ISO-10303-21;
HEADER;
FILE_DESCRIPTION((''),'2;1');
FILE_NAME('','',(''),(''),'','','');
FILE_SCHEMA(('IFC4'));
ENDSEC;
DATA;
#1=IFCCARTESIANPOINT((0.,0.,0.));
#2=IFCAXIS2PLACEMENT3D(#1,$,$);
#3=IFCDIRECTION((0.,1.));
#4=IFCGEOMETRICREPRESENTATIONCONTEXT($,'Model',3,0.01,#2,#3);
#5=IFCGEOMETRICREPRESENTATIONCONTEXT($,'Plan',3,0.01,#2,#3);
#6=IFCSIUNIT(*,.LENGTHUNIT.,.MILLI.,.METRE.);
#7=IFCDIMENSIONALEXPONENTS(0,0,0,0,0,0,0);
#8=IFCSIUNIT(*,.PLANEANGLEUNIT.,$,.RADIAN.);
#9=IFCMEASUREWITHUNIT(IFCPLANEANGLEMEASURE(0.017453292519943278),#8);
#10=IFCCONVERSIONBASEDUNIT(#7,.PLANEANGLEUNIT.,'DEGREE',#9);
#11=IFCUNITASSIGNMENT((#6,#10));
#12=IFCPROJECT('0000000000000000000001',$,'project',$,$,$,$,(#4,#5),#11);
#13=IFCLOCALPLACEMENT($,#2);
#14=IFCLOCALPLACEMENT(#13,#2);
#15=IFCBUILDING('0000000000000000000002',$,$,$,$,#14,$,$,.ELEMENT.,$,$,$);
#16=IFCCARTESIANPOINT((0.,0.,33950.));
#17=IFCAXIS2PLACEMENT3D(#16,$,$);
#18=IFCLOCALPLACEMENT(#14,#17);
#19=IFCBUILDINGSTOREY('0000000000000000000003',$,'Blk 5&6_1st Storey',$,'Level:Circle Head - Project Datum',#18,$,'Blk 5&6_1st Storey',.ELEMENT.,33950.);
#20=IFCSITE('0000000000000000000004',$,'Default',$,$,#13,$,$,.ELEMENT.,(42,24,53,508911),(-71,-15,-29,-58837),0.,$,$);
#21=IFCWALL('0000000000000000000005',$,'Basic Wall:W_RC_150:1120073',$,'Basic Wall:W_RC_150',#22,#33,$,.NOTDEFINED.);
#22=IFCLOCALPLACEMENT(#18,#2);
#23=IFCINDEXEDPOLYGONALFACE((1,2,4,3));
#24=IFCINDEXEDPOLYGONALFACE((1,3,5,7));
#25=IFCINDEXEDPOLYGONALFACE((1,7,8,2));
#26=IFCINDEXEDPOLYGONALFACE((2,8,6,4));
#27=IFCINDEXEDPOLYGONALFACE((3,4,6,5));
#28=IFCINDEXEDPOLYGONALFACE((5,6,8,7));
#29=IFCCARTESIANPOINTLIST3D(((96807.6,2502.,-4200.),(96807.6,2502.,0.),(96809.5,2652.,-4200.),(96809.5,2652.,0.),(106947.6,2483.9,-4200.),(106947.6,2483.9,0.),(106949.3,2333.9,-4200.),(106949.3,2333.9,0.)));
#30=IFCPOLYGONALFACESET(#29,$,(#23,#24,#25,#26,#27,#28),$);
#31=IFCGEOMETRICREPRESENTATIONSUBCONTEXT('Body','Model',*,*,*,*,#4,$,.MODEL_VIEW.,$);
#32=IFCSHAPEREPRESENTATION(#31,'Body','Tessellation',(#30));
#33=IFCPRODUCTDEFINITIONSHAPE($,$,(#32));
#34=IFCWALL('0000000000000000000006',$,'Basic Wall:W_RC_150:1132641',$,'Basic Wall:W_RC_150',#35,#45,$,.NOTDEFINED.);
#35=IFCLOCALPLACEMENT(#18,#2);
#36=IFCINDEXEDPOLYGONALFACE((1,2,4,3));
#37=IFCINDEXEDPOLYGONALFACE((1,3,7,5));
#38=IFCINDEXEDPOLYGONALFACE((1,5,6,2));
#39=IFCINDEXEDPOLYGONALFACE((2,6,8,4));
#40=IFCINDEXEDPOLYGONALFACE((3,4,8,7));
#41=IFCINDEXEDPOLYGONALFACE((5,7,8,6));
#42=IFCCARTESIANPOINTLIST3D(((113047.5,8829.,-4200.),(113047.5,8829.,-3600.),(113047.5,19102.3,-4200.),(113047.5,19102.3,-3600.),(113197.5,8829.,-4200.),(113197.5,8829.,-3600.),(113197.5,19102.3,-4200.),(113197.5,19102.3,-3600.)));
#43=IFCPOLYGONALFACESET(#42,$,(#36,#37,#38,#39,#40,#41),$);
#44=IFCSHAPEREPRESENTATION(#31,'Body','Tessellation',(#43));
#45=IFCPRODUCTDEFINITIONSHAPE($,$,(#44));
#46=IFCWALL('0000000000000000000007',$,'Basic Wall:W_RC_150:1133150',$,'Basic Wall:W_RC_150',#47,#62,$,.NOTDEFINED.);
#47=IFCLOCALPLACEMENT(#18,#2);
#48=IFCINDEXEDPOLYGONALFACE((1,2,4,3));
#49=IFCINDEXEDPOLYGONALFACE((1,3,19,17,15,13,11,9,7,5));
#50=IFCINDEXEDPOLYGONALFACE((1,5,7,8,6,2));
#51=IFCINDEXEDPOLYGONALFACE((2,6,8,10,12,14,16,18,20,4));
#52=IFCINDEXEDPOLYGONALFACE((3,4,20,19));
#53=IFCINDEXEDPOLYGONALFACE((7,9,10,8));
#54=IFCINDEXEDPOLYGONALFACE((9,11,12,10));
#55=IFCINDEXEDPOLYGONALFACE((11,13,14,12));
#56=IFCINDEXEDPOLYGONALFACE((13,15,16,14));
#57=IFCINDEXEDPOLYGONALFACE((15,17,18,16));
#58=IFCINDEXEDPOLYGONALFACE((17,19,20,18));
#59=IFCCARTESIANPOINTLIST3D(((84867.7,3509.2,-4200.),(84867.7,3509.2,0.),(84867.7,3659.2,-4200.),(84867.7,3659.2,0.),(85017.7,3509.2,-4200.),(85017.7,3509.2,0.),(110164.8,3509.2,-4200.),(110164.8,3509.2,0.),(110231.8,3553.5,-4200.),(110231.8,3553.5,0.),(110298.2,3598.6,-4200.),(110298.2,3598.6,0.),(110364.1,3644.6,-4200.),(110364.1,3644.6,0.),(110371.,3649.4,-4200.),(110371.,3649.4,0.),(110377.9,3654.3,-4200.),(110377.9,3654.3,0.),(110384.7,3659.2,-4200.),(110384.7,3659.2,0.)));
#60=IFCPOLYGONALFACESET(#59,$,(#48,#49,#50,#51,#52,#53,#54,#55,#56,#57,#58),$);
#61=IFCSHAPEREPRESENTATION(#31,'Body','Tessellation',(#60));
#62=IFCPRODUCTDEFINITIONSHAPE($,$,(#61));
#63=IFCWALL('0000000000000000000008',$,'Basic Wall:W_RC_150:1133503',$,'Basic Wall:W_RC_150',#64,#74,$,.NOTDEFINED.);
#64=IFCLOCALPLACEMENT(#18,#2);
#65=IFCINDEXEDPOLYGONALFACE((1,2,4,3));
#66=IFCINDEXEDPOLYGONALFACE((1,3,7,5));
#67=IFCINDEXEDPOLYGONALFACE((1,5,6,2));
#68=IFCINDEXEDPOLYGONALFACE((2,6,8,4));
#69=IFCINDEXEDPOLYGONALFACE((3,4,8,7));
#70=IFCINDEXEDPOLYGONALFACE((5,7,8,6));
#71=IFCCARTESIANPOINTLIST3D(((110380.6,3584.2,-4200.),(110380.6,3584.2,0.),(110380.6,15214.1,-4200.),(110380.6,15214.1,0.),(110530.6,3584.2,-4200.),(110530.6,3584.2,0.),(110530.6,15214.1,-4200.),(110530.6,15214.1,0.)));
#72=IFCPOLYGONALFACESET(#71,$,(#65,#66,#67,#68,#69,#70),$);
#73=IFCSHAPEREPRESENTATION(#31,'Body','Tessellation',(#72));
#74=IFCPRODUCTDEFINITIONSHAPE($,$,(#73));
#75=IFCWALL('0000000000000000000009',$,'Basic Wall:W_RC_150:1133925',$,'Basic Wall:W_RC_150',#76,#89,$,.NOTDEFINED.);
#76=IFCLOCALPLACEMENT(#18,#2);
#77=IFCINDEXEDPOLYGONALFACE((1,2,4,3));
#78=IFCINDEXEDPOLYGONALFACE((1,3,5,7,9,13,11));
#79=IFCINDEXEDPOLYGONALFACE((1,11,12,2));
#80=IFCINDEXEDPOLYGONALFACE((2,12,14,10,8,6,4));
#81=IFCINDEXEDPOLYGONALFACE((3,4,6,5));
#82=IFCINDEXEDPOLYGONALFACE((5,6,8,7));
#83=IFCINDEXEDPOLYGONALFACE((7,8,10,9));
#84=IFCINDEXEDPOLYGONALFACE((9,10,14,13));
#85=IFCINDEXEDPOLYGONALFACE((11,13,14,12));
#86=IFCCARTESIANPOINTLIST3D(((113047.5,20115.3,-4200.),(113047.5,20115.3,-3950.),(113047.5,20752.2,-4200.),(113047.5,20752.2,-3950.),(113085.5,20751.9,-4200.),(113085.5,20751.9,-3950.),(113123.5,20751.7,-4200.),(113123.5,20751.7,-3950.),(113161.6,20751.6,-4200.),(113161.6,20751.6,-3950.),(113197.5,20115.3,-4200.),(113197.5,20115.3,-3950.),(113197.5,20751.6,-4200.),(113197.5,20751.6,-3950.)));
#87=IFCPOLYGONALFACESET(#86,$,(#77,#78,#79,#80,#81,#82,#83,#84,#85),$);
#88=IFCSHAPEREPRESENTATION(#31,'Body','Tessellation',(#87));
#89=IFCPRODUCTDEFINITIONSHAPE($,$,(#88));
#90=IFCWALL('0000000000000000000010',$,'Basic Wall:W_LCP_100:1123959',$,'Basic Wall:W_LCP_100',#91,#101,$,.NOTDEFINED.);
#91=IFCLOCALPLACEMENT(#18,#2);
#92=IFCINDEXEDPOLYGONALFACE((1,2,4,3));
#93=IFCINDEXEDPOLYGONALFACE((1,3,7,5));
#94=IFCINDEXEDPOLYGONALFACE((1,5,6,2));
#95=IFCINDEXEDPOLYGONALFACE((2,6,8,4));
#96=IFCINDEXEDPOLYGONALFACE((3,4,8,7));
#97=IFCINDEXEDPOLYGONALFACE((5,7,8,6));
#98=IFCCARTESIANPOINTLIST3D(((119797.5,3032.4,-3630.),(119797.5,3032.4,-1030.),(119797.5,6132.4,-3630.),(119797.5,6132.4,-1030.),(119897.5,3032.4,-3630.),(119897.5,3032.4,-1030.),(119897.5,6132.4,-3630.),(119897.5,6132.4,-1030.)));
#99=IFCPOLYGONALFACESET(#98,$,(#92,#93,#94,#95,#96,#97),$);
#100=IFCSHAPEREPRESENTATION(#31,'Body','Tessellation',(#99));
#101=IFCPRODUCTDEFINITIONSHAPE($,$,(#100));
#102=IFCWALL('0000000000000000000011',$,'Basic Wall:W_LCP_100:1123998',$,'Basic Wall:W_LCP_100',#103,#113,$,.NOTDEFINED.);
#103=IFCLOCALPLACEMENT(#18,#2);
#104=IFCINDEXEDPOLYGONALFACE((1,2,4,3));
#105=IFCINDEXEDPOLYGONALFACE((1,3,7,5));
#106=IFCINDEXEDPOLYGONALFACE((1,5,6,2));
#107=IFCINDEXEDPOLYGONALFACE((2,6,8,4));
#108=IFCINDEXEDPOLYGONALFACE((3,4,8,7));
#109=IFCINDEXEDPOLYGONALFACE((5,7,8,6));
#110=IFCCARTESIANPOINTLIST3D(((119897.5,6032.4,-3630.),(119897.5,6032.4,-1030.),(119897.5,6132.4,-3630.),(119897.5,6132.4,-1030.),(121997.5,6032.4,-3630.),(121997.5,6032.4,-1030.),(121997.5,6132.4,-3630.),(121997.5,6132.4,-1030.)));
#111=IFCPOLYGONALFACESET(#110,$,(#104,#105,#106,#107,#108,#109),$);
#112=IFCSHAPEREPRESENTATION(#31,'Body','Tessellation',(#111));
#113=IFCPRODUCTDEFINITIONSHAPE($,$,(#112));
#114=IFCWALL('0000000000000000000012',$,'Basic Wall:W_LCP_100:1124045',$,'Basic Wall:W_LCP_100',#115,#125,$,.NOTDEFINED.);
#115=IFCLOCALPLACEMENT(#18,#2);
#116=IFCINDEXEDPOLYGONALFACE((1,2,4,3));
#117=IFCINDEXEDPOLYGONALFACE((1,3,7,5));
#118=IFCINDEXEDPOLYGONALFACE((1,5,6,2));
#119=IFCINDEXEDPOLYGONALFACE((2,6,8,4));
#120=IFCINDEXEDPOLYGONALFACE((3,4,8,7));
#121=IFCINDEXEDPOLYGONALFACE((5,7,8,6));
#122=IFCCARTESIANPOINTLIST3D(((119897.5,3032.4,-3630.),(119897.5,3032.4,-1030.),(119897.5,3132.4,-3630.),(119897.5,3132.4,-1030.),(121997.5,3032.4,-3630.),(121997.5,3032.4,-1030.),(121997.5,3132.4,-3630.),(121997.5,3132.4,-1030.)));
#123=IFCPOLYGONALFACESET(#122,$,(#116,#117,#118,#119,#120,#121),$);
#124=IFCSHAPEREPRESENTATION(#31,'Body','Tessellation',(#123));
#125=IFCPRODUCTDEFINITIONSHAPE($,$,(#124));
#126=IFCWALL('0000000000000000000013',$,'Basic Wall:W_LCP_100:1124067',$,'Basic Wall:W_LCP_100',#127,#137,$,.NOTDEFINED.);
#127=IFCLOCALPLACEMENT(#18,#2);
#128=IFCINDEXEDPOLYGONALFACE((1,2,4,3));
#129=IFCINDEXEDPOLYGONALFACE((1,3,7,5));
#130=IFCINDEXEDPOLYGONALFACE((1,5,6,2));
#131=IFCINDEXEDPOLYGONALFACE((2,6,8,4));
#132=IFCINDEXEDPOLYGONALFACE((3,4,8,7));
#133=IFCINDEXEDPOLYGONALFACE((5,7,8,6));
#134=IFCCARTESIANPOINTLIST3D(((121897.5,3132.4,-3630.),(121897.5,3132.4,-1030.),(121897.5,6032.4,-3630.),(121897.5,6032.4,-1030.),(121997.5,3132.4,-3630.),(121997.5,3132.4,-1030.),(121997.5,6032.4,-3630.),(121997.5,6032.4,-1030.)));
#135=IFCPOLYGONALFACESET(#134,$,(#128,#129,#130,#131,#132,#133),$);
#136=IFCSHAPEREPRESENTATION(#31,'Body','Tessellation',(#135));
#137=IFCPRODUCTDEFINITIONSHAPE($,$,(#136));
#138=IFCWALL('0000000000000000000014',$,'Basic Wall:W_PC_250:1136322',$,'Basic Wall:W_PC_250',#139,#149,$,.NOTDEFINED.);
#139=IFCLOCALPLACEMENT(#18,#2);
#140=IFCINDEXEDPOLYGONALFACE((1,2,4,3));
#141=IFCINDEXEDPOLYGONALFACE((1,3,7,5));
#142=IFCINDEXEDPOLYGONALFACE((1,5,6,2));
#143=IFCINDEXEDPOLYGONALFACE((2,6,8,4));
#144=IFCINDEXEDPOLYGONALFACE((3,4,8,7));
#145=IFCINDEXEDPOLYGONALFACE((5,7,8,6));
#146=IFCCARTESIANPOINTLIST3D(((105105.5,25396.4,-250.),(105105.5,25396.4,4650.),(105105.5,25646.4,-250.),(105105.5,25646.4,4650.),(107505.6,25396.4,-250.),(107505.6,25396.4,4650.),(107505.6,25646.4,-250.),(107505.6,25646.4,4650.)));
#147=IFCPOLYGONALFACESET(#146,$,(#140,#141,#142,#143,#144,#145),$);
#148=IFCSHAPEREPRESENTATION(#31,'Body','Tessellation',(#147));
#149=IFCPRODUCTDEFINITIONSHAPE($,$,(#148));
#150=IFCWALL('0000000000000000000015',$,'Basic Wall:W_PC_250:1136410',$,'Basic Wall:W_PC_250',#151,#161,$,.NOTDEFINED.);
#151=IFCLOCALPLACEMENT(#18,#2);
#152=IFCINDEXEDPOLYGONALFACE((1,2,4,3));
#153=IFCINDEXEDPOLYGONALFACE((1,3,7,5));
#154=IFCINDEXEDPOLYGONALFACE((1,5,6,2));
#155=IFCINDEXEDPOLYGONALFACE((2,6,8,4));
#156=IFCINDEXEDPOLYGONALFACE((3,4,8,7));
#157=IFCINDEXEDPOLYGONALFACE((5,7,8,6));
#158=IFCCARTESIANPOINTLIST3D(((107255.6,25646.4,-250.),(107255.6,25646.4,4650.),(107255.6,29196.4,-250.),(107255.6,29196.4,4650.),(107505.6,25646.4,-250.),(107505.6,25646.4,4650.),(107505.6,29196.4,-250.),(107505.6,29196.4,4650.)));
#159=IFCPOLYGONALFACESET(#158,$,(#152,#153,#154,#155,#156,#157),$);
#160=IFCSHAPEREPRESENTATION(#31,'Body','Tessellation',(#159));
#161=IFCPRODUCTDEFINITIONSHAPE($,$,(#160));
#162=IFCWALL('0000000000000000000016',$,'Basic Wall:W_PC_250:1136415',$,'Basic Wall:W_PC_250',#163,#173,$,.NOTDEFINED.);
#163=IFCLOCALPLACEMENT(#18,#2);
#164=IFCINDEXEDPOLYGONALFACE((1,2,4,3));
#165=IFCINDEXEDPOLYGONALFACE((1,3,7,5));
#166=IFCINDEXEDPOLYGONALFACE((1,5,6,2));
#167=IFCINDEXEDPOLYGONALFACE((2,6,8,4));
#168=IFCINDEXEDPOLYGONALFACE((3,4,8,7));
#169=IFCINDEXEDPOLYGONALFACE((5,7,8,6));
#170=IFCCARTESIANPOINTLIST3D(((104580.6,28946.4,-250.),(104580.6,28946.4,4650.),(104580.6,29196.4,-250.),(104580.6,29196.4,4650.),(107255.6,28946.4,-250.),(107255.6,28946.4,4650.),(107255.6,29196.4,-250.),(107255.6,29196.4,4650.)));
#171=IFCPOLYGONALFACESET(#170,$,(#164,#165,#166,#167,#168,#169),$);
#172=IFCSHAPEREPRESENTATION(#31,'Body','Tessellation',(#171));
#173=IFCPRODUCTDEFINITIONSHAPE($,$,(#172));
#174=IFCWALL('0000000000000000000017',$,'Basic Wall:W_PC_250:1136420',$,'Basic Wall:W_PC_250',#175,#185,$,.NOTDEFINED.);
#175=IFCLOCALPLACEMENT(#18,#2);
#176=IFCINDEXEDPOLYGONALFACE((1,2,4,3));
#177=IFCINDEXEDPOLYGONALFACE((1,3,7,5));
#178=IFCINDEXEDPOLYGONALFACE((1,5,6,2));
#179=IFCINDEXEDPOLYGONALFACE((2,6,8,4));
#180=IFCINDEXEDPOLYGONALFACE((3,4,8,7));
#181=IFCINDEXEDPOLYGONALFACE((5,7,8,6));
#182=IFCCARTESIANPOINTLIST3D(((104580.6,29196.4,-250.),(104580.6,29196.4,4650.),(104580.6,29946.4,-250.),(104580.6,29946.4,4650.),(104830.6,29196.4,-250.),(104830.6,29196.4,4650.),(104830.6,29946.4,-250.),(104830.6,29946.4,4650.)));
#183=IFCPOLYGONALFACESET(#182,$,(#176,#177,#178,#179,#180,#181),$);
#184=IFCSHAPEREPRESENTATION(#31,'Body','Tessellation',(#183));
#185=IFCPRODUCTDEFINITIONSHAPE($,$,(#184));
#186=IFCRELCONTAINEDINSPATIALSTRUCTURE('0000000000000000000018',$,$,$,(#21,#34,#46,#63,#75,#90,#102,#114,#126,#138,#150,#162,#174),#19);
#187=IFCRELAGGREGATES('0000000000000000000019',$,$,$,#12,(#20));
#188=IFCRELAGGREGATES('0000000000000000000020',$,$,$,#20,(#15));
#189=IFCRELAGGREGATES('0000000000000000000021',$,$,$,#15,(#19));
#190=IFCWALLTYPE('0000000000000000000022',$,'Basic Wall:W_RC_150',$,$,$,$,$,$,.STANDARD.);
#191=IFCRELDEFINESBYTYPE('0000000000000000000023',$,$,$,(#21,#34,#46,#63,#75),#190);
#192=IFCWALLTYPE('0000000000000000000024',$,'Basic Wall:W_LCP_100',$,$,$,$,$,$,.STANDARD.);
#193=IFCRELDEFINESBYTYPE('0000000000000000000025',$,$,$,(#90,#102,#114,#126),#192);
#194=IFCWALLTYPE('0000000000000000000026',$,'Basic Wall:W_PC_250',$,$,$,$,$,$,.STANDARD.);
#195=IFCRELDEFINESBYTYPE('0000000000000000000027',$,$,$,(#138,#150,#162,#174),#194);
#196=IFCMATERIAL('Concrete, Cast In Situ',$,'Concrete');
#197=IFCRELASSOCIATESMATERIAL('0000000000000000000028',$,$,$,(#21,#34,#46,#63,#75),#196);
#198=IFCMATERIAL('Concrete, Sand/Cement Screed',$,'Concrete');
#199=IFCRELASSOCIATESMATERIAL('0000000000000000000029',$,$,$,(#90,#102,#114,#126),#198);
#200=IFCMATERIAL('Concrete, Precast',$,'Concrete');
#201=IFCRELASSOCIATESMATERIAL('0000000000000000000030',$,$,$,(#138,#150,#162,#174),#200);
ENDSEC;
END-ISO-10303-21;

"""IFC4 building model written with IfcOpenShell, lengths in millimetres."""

from ifc_helpers import new_model, entity, si_unit, converted_unit, direction, frame, origin, place, context, subcontext, project, spatial, line, arc, indexed_curve, outline, extrude, material, type_object, element, save


model = new_model("IFC4")

# Units and contexts
model_context = context("Model", 3, precision=0.01, world=origin(), true_north=direction((0.0, 1.0)))
plan_context = context("Plan", 3, precision=0.01, world=origin(), true_north=direction((0.0, 1.0)))
body_context = subcontext(model_context, "Body", "Model", "MODEL_VIEW")
ifc_project = project(units=[si_unit("LENGTHUNIT", "METRE", prefix="MILLI"), converted_unit("PLANEANGLEUNIT", "DEGREE", entity("IfcPlaneAngleMeasure", 0.017453292519943278), si_unit("PLANEANGLEUNIT", "RADIAN"), dimensions=[0, 0, 0, 0, 0, 0, 0])], contexts=[model_context, plan_context])

# Site, building, storey
site_placement = place(None, origin())
site = spatial("IfcSite", under=ifc_project, at=site_placement, Name="Default", CompositionType="ELEMENT", RefLatitude=(42, 24, 53, 508911), RefLongitude=(-71, -15, -29, -58837), RefElevation=0.0)
building_placement = place(site_placement, origin())
building = spatial("IfcBuilding", under=site, at=building_placement, CompositionType="ELEMENT")
storey_placement = place(building_placement, frame((0.0, 0.0, 33950.0)))
storey = spatial("IfcBuildingStorey", under=building, at=storey_placement, Name="Blk 5&6_1st Storey", ObjectType="Level:Circle Head - Project Datum", LongName="Blk 5&6_1st Storey", CompositionType="ELEMENT", Elevation=33950.0)

# Walls
ifc_material_1 = material(Name="Concrete, Cast In Situ", Category="Concrete")
wall_type_1 = type_object("IfcWallType", Name="Basic Wall:W_RC_150", PredefinedType="STANDARD")
wall_1_placement = place(storey_placement, frame((106950.5, 2408.9, -4200.0), z_axis=(0.0, 0.0, 1.0), x_axis=(-0.999863, 0.016573, 0.0)))
element("IfcWall", 1, at=wall_1_placement, inside=storey, type_object=wall_type_1, material=ifc_material_1, Name="Basic Wall:W_RC_150:1120073", ObjectType="Basic Wall:W_RC_150", PredefinedType="NOTDEFINED", context=body_context, shape_type="SweptSolid", body=[
    extrude(outline(indexed_curve([(10143.7, -75.0), (10143.1, 75.0), (0.0, 75.0), (4.2, -75.0), (10143.7, -75.0)], self_intersect=False)), origin(), (0.0, 0.0, 1.0), 4200.0),
])
wall_2_placement = place(storey_placement, frame((113122.5, 8829.0, -4200.0), z_axis=(0.0, 0.0, 1.0), x_axis=(0.0, 1.0, 0.0)))
element("IfcWall", 2, at=wall_2_placement, inside=storey, type_object=wall_type_1, material=ifc_material_1, Name="Basic Wall:W_RC_150:1132641", ObjectType="Basic Wall:W_RC_150", PredefinedType="NOTDEFINED", context=body_context, shape_type="SweptSolid", body=[
    extrude(outline(indexed_curve([(10273.3, 75.0), (0.0, 75.0), (0.0, -75.0), (10273.3, -75.0), (10273.3, 75.0)], self_intersect=False)), origin(), (0.0, 0.0, 1.0), 600.0),
])
wall_3_placement = place(storey_placement, frame((110384.7, 3584.2, -4200.0), z_axis=(0.0, 0.0, 1.0), x_axis=(-1.0, 0.0, 0.0)))
element("IfcWall", 3, at=wall_3_placement, inside=storey, type_object=wall_type_1, material=ifc_material_1, Name="Basic Wall:W_RC_150:1133150", ObjectType="Basic Wall:W_RC_150", PredefinedType="NOTDEFINED", context=body_context, shape_type="SweptSolid", body=[
    extrude(outline(indexed_curve([(25517.0, -75.0), (25517.0, 75.0), (25367.0, 75.0), (219.9, 75.0), (119.6, 8.3), (20.6, -60.3), (10.3, -67.7), (0.0, -75.0)], segments=[line(1, 2, 3, 4), arc(4, 5, 6), arc(6, 7, 8), line(8, 1)], self_intersect=False)), origin(), (0.0, 0.0, 1.0), 4200.0),
])
wall_4_placement = place(storey_placement, frame((110455.6, 15214.1, -4200.0), z_axis=(0.0, 0.0, 1.0), x_axis=(0.0, -1.0, 0.0)))
element("IfcWall", 4, at=wall_4_placement, inside=storey, type_object=wall_type_1, material=ifc_material_1, Name="Basic Wall:W_RC_150:1133503", ObjectType="Basic Wall:W_RC_150", PredefinedType="NOTDEFINED", context=body_context, shape_type="SweptSolid", body=[
    extrude(outline(indexed_curve([(11629.9, 75.0), (0.0, 75.0), (0.0, -75.0), (11629.9, -75.0), (11629.9, 75.0)], self_intersect=False)), origin(), (0.0, 0.0, 1.0), 4200.0),
])
wall_5_placement = place(storey_placement, frame((113122.5, 20115.3, -4200.0), z_axis=(0.0, 0.0, 1.0), x_axis=(0.0, 1.0, 0.0)))
element("IfcWall", 5, at=wall_5_placement, inside=storey, type_object=wall_type_1, material=ifc_material_1, Name="Basic Wall:W_RC_150:1133925", ObjectType="Basic Wall:W_RC_150", PredefinedType="NOTDEFINED", context=body_context, shape_type="SweptSolid", body=[
    extrude(outline(indexed_curve([(636.3, -75.0), (636.3, -39.1), (636.5, 18.0), (636.9, 75.0), (0.0, 75.0), (0.0, -75.0)], segments=[line(1, 2), arc(2, 3, 4), line(4, 5, 6, 1)], self_intersect=False)), origin(), (0.0, 0.0, 1.0), 250.0),
])
ifc_material_2 = material(Name="Concrete, Sand/Cement Screed", Category="Concrete")
wall_type_2 = type_object("IfcWallType", Name="Basic Wall:W_LCP_100", PredefinedType="STANDARD")
wall_6_placement = place(storey_placement, frame((119847.5, 6132.4, -3630.0), z_axis=(0.0, 0.0, 1.0), x_axis=(0.0, -1.0, 0.0)))
element("IfcWall", 6, at=wall_6_placement, inside=storey, type_object=wall_type_2, material=ifc_material_2, Name="Basic Wall:W_LCP_100:1123959", ObjectType="Basic Wall:W_LCP_100", PredefinedType="NOTDEFINED", context=body_context, shape_type="SweptSolid", body=[
    extrude(outline(indexed_curve([(3100.0, 50.0), (0.0, 50.0), (0.0, -50.0), (3100.0, -50.0), (3100.0, 50.0)], self_intersect=False)), origin(), (0.0, 0.0, 1.0), 2600.0),
])
wall_7_placement = place(storey_placement, frame((119897.5, 6082.4, -3630.0)))
element("IfcWall", 7, at=wall_7_placement, inside=storey, type_object=wall_type_2, material=ifc_material_2, Name="Basic Wall:W_LCP_100:1123998", ObjectType="Basic Wall:W_LCP_100", PredefinedType="NOTDEFINED", context=body_context, shape_type="SweptSolid", body=[
    extrude(outline(indexed_curve([(2100.0, 50.0), (0.0, 50.0), (0.0, -50.0), (2100.0, -50.0), (2100.0, 50.0)], self_intersect=False)), origin(), (0.0, 0.0, 1.0), 2600.0),
])
wall_8_placement = place(storey_placement, frame((119897.5, 3082.4, -3630.0)))
element("IfcWall", 8, at=wall_8_placement, inside=storey, type_object=wall_type_2, material=ifc_material_2, Name="Basic Wall:W_LCP_100:1124045", ObjectType="Basic Wall:W_LCP_100", PredefinedType="NOTDEFINED", context=body_context, shape_type="SweptSolid", body=[
    extrude(outline(indexed_curve([(2100.0, 50.0), (0.0, 50.0), (0.0, -50.0), (2100.0, -50.0), (2100.0, 50.0)], self_intersect=False)), origin(), (0.0, 0.0, 1.0), 2600.0),
])
wall_9_placement = place(storey_placement, frame((121947.5, 6032.4, -3630.0), z_axis=(0.0, 0.0, 1.0), x_axis=(0.0, -1.0, 0.0)))
element("IfcWall", 9, at=wall_9_placement, inside=storey, type_object=wall_type_2, material=ifc_material_2, Name="Basic Wall:W_LCP_100:1124067", ObjectType="Basic Wall:W_LCP_100", PredefinedType="NOTDEFINED", context=body_context, shape_type="SweptSolid", body=[
    extrude(outline(indexed_curve([(2900.0, 50.0), (0.0, 50.0), (0.0, -50.0), (2900.0, -50.0), (2900.0, 50.0)], self_intersect=False)), origin(), (0.0, 0.0, 1.0), 2600.0),
])
ifc_material_3 = material(Name="Concrete, Precast", Category="Concrete")
wall_type_3 = type_object("IfcWallType", Name="Basic Wall:W_PC_250", PredefinedType="STANDARD")
wall_10_placement = place(storey_placement, frame((105105.5, 25521.4, -250.0)))
element("IfcWall", 10, at=wall_10_placement, inside=storey, type_object=wall_type_3, material=ifc_material_3, Name="Basic Wall:W_PC_250:1136322", ObjectType="Basic Wall:W_PC_250", PredefinedType="NOTDEFINED", context=body_context, shape_type="SweptSolid", body=[
    extrude(outline(indexed_curve([(2400.2, 125.0), (0.0, 125.0), (0.0, -125.0), (2400.2, -125.0), (2400.2, 125.0)], self_intersect=False)), origin(), (0.0, 0.0, 1.0), 4900.0),
])
wall_11_placement = place(storey_placement, frame((107380.6, 25646.4, -250.0), z_axis=(0.0, 0.0, 1.0), x_axis=(0.0, 1.0, 0.0)))
element("IfcWall", 11, at=wall_11_placement, inside=storey, type_object=wall_type_3, material=ifc_material_3, Name="Basic Wall:W_PC_250:1136410", ObjectType="Basic Wall:W_PC_250", PredefinedType="NOTDEFINED", context=body_context, shape_type="SweptSolid", body=[
    extrude(outline(indexed_curve([(3550.0, 125.0), (0.0, 125.0), (0.0, -125.0), (3550.0, -125.0), (3550.0, 125.0)], self_intersect=False)), origin(), (0.0, 0.0, 1.0), 4900.0),
])
wall_12_placement = place(storey_placement, frame((107255.6, 29071.4, -250.0), z_axis=(0.0, 0.0, 1.0), x_axis=(-1.0, 0.0, 0.0)))
element("IfcWall", 12, at=wall_12_placement, inside=storey, type_object=wall_type_3, material=ifc_material_3, Name="Basic Wall:W_PC_250:1136415", ObjectType="Basic Wall:W_PC_250", PredefinedType="NOTDEFINED", context=body_context, shape_type="SweptSolid", body=[
    extrude(outline(indexed_curve([(2675.0, 125.0), (0.0, 125.0), (0.0, -125.0), (2675.0, -125.0), (2675.0, 125.0)], self_intersect=False)), origin(), (0.0, 0.0, 1.0), 4900.0),
])
wall_13_placement = place(storey_placement, frame((104705.6, 29196.4, -250.0), z_axis=(0.0, 0.0, 1.0), x_axis=(0.0, 1.0, 0.0)))
element("IfcWall", 13, at=wall_13_placement, inside=storey, type_object=wall_type_3, material=ifc_material_3, Name="Basic Wall:W_PC_250:1136420", ObjectType="Basic Wall:W_PC_250", PredefinedType="NOTDEFINED", context=body_context, shape_type="SweptSolid", body=[
    extrude(outline(indexed_curve([(750.0, 125.0), (0.0, 125.0), (0.0, -125.0), (750.0, -125.0), (750.0, 125.0)], self_intersect=False)), origin(), (0.0, 0.0, 1.0), 4900.0),
])

save(model, "model.ifc")
